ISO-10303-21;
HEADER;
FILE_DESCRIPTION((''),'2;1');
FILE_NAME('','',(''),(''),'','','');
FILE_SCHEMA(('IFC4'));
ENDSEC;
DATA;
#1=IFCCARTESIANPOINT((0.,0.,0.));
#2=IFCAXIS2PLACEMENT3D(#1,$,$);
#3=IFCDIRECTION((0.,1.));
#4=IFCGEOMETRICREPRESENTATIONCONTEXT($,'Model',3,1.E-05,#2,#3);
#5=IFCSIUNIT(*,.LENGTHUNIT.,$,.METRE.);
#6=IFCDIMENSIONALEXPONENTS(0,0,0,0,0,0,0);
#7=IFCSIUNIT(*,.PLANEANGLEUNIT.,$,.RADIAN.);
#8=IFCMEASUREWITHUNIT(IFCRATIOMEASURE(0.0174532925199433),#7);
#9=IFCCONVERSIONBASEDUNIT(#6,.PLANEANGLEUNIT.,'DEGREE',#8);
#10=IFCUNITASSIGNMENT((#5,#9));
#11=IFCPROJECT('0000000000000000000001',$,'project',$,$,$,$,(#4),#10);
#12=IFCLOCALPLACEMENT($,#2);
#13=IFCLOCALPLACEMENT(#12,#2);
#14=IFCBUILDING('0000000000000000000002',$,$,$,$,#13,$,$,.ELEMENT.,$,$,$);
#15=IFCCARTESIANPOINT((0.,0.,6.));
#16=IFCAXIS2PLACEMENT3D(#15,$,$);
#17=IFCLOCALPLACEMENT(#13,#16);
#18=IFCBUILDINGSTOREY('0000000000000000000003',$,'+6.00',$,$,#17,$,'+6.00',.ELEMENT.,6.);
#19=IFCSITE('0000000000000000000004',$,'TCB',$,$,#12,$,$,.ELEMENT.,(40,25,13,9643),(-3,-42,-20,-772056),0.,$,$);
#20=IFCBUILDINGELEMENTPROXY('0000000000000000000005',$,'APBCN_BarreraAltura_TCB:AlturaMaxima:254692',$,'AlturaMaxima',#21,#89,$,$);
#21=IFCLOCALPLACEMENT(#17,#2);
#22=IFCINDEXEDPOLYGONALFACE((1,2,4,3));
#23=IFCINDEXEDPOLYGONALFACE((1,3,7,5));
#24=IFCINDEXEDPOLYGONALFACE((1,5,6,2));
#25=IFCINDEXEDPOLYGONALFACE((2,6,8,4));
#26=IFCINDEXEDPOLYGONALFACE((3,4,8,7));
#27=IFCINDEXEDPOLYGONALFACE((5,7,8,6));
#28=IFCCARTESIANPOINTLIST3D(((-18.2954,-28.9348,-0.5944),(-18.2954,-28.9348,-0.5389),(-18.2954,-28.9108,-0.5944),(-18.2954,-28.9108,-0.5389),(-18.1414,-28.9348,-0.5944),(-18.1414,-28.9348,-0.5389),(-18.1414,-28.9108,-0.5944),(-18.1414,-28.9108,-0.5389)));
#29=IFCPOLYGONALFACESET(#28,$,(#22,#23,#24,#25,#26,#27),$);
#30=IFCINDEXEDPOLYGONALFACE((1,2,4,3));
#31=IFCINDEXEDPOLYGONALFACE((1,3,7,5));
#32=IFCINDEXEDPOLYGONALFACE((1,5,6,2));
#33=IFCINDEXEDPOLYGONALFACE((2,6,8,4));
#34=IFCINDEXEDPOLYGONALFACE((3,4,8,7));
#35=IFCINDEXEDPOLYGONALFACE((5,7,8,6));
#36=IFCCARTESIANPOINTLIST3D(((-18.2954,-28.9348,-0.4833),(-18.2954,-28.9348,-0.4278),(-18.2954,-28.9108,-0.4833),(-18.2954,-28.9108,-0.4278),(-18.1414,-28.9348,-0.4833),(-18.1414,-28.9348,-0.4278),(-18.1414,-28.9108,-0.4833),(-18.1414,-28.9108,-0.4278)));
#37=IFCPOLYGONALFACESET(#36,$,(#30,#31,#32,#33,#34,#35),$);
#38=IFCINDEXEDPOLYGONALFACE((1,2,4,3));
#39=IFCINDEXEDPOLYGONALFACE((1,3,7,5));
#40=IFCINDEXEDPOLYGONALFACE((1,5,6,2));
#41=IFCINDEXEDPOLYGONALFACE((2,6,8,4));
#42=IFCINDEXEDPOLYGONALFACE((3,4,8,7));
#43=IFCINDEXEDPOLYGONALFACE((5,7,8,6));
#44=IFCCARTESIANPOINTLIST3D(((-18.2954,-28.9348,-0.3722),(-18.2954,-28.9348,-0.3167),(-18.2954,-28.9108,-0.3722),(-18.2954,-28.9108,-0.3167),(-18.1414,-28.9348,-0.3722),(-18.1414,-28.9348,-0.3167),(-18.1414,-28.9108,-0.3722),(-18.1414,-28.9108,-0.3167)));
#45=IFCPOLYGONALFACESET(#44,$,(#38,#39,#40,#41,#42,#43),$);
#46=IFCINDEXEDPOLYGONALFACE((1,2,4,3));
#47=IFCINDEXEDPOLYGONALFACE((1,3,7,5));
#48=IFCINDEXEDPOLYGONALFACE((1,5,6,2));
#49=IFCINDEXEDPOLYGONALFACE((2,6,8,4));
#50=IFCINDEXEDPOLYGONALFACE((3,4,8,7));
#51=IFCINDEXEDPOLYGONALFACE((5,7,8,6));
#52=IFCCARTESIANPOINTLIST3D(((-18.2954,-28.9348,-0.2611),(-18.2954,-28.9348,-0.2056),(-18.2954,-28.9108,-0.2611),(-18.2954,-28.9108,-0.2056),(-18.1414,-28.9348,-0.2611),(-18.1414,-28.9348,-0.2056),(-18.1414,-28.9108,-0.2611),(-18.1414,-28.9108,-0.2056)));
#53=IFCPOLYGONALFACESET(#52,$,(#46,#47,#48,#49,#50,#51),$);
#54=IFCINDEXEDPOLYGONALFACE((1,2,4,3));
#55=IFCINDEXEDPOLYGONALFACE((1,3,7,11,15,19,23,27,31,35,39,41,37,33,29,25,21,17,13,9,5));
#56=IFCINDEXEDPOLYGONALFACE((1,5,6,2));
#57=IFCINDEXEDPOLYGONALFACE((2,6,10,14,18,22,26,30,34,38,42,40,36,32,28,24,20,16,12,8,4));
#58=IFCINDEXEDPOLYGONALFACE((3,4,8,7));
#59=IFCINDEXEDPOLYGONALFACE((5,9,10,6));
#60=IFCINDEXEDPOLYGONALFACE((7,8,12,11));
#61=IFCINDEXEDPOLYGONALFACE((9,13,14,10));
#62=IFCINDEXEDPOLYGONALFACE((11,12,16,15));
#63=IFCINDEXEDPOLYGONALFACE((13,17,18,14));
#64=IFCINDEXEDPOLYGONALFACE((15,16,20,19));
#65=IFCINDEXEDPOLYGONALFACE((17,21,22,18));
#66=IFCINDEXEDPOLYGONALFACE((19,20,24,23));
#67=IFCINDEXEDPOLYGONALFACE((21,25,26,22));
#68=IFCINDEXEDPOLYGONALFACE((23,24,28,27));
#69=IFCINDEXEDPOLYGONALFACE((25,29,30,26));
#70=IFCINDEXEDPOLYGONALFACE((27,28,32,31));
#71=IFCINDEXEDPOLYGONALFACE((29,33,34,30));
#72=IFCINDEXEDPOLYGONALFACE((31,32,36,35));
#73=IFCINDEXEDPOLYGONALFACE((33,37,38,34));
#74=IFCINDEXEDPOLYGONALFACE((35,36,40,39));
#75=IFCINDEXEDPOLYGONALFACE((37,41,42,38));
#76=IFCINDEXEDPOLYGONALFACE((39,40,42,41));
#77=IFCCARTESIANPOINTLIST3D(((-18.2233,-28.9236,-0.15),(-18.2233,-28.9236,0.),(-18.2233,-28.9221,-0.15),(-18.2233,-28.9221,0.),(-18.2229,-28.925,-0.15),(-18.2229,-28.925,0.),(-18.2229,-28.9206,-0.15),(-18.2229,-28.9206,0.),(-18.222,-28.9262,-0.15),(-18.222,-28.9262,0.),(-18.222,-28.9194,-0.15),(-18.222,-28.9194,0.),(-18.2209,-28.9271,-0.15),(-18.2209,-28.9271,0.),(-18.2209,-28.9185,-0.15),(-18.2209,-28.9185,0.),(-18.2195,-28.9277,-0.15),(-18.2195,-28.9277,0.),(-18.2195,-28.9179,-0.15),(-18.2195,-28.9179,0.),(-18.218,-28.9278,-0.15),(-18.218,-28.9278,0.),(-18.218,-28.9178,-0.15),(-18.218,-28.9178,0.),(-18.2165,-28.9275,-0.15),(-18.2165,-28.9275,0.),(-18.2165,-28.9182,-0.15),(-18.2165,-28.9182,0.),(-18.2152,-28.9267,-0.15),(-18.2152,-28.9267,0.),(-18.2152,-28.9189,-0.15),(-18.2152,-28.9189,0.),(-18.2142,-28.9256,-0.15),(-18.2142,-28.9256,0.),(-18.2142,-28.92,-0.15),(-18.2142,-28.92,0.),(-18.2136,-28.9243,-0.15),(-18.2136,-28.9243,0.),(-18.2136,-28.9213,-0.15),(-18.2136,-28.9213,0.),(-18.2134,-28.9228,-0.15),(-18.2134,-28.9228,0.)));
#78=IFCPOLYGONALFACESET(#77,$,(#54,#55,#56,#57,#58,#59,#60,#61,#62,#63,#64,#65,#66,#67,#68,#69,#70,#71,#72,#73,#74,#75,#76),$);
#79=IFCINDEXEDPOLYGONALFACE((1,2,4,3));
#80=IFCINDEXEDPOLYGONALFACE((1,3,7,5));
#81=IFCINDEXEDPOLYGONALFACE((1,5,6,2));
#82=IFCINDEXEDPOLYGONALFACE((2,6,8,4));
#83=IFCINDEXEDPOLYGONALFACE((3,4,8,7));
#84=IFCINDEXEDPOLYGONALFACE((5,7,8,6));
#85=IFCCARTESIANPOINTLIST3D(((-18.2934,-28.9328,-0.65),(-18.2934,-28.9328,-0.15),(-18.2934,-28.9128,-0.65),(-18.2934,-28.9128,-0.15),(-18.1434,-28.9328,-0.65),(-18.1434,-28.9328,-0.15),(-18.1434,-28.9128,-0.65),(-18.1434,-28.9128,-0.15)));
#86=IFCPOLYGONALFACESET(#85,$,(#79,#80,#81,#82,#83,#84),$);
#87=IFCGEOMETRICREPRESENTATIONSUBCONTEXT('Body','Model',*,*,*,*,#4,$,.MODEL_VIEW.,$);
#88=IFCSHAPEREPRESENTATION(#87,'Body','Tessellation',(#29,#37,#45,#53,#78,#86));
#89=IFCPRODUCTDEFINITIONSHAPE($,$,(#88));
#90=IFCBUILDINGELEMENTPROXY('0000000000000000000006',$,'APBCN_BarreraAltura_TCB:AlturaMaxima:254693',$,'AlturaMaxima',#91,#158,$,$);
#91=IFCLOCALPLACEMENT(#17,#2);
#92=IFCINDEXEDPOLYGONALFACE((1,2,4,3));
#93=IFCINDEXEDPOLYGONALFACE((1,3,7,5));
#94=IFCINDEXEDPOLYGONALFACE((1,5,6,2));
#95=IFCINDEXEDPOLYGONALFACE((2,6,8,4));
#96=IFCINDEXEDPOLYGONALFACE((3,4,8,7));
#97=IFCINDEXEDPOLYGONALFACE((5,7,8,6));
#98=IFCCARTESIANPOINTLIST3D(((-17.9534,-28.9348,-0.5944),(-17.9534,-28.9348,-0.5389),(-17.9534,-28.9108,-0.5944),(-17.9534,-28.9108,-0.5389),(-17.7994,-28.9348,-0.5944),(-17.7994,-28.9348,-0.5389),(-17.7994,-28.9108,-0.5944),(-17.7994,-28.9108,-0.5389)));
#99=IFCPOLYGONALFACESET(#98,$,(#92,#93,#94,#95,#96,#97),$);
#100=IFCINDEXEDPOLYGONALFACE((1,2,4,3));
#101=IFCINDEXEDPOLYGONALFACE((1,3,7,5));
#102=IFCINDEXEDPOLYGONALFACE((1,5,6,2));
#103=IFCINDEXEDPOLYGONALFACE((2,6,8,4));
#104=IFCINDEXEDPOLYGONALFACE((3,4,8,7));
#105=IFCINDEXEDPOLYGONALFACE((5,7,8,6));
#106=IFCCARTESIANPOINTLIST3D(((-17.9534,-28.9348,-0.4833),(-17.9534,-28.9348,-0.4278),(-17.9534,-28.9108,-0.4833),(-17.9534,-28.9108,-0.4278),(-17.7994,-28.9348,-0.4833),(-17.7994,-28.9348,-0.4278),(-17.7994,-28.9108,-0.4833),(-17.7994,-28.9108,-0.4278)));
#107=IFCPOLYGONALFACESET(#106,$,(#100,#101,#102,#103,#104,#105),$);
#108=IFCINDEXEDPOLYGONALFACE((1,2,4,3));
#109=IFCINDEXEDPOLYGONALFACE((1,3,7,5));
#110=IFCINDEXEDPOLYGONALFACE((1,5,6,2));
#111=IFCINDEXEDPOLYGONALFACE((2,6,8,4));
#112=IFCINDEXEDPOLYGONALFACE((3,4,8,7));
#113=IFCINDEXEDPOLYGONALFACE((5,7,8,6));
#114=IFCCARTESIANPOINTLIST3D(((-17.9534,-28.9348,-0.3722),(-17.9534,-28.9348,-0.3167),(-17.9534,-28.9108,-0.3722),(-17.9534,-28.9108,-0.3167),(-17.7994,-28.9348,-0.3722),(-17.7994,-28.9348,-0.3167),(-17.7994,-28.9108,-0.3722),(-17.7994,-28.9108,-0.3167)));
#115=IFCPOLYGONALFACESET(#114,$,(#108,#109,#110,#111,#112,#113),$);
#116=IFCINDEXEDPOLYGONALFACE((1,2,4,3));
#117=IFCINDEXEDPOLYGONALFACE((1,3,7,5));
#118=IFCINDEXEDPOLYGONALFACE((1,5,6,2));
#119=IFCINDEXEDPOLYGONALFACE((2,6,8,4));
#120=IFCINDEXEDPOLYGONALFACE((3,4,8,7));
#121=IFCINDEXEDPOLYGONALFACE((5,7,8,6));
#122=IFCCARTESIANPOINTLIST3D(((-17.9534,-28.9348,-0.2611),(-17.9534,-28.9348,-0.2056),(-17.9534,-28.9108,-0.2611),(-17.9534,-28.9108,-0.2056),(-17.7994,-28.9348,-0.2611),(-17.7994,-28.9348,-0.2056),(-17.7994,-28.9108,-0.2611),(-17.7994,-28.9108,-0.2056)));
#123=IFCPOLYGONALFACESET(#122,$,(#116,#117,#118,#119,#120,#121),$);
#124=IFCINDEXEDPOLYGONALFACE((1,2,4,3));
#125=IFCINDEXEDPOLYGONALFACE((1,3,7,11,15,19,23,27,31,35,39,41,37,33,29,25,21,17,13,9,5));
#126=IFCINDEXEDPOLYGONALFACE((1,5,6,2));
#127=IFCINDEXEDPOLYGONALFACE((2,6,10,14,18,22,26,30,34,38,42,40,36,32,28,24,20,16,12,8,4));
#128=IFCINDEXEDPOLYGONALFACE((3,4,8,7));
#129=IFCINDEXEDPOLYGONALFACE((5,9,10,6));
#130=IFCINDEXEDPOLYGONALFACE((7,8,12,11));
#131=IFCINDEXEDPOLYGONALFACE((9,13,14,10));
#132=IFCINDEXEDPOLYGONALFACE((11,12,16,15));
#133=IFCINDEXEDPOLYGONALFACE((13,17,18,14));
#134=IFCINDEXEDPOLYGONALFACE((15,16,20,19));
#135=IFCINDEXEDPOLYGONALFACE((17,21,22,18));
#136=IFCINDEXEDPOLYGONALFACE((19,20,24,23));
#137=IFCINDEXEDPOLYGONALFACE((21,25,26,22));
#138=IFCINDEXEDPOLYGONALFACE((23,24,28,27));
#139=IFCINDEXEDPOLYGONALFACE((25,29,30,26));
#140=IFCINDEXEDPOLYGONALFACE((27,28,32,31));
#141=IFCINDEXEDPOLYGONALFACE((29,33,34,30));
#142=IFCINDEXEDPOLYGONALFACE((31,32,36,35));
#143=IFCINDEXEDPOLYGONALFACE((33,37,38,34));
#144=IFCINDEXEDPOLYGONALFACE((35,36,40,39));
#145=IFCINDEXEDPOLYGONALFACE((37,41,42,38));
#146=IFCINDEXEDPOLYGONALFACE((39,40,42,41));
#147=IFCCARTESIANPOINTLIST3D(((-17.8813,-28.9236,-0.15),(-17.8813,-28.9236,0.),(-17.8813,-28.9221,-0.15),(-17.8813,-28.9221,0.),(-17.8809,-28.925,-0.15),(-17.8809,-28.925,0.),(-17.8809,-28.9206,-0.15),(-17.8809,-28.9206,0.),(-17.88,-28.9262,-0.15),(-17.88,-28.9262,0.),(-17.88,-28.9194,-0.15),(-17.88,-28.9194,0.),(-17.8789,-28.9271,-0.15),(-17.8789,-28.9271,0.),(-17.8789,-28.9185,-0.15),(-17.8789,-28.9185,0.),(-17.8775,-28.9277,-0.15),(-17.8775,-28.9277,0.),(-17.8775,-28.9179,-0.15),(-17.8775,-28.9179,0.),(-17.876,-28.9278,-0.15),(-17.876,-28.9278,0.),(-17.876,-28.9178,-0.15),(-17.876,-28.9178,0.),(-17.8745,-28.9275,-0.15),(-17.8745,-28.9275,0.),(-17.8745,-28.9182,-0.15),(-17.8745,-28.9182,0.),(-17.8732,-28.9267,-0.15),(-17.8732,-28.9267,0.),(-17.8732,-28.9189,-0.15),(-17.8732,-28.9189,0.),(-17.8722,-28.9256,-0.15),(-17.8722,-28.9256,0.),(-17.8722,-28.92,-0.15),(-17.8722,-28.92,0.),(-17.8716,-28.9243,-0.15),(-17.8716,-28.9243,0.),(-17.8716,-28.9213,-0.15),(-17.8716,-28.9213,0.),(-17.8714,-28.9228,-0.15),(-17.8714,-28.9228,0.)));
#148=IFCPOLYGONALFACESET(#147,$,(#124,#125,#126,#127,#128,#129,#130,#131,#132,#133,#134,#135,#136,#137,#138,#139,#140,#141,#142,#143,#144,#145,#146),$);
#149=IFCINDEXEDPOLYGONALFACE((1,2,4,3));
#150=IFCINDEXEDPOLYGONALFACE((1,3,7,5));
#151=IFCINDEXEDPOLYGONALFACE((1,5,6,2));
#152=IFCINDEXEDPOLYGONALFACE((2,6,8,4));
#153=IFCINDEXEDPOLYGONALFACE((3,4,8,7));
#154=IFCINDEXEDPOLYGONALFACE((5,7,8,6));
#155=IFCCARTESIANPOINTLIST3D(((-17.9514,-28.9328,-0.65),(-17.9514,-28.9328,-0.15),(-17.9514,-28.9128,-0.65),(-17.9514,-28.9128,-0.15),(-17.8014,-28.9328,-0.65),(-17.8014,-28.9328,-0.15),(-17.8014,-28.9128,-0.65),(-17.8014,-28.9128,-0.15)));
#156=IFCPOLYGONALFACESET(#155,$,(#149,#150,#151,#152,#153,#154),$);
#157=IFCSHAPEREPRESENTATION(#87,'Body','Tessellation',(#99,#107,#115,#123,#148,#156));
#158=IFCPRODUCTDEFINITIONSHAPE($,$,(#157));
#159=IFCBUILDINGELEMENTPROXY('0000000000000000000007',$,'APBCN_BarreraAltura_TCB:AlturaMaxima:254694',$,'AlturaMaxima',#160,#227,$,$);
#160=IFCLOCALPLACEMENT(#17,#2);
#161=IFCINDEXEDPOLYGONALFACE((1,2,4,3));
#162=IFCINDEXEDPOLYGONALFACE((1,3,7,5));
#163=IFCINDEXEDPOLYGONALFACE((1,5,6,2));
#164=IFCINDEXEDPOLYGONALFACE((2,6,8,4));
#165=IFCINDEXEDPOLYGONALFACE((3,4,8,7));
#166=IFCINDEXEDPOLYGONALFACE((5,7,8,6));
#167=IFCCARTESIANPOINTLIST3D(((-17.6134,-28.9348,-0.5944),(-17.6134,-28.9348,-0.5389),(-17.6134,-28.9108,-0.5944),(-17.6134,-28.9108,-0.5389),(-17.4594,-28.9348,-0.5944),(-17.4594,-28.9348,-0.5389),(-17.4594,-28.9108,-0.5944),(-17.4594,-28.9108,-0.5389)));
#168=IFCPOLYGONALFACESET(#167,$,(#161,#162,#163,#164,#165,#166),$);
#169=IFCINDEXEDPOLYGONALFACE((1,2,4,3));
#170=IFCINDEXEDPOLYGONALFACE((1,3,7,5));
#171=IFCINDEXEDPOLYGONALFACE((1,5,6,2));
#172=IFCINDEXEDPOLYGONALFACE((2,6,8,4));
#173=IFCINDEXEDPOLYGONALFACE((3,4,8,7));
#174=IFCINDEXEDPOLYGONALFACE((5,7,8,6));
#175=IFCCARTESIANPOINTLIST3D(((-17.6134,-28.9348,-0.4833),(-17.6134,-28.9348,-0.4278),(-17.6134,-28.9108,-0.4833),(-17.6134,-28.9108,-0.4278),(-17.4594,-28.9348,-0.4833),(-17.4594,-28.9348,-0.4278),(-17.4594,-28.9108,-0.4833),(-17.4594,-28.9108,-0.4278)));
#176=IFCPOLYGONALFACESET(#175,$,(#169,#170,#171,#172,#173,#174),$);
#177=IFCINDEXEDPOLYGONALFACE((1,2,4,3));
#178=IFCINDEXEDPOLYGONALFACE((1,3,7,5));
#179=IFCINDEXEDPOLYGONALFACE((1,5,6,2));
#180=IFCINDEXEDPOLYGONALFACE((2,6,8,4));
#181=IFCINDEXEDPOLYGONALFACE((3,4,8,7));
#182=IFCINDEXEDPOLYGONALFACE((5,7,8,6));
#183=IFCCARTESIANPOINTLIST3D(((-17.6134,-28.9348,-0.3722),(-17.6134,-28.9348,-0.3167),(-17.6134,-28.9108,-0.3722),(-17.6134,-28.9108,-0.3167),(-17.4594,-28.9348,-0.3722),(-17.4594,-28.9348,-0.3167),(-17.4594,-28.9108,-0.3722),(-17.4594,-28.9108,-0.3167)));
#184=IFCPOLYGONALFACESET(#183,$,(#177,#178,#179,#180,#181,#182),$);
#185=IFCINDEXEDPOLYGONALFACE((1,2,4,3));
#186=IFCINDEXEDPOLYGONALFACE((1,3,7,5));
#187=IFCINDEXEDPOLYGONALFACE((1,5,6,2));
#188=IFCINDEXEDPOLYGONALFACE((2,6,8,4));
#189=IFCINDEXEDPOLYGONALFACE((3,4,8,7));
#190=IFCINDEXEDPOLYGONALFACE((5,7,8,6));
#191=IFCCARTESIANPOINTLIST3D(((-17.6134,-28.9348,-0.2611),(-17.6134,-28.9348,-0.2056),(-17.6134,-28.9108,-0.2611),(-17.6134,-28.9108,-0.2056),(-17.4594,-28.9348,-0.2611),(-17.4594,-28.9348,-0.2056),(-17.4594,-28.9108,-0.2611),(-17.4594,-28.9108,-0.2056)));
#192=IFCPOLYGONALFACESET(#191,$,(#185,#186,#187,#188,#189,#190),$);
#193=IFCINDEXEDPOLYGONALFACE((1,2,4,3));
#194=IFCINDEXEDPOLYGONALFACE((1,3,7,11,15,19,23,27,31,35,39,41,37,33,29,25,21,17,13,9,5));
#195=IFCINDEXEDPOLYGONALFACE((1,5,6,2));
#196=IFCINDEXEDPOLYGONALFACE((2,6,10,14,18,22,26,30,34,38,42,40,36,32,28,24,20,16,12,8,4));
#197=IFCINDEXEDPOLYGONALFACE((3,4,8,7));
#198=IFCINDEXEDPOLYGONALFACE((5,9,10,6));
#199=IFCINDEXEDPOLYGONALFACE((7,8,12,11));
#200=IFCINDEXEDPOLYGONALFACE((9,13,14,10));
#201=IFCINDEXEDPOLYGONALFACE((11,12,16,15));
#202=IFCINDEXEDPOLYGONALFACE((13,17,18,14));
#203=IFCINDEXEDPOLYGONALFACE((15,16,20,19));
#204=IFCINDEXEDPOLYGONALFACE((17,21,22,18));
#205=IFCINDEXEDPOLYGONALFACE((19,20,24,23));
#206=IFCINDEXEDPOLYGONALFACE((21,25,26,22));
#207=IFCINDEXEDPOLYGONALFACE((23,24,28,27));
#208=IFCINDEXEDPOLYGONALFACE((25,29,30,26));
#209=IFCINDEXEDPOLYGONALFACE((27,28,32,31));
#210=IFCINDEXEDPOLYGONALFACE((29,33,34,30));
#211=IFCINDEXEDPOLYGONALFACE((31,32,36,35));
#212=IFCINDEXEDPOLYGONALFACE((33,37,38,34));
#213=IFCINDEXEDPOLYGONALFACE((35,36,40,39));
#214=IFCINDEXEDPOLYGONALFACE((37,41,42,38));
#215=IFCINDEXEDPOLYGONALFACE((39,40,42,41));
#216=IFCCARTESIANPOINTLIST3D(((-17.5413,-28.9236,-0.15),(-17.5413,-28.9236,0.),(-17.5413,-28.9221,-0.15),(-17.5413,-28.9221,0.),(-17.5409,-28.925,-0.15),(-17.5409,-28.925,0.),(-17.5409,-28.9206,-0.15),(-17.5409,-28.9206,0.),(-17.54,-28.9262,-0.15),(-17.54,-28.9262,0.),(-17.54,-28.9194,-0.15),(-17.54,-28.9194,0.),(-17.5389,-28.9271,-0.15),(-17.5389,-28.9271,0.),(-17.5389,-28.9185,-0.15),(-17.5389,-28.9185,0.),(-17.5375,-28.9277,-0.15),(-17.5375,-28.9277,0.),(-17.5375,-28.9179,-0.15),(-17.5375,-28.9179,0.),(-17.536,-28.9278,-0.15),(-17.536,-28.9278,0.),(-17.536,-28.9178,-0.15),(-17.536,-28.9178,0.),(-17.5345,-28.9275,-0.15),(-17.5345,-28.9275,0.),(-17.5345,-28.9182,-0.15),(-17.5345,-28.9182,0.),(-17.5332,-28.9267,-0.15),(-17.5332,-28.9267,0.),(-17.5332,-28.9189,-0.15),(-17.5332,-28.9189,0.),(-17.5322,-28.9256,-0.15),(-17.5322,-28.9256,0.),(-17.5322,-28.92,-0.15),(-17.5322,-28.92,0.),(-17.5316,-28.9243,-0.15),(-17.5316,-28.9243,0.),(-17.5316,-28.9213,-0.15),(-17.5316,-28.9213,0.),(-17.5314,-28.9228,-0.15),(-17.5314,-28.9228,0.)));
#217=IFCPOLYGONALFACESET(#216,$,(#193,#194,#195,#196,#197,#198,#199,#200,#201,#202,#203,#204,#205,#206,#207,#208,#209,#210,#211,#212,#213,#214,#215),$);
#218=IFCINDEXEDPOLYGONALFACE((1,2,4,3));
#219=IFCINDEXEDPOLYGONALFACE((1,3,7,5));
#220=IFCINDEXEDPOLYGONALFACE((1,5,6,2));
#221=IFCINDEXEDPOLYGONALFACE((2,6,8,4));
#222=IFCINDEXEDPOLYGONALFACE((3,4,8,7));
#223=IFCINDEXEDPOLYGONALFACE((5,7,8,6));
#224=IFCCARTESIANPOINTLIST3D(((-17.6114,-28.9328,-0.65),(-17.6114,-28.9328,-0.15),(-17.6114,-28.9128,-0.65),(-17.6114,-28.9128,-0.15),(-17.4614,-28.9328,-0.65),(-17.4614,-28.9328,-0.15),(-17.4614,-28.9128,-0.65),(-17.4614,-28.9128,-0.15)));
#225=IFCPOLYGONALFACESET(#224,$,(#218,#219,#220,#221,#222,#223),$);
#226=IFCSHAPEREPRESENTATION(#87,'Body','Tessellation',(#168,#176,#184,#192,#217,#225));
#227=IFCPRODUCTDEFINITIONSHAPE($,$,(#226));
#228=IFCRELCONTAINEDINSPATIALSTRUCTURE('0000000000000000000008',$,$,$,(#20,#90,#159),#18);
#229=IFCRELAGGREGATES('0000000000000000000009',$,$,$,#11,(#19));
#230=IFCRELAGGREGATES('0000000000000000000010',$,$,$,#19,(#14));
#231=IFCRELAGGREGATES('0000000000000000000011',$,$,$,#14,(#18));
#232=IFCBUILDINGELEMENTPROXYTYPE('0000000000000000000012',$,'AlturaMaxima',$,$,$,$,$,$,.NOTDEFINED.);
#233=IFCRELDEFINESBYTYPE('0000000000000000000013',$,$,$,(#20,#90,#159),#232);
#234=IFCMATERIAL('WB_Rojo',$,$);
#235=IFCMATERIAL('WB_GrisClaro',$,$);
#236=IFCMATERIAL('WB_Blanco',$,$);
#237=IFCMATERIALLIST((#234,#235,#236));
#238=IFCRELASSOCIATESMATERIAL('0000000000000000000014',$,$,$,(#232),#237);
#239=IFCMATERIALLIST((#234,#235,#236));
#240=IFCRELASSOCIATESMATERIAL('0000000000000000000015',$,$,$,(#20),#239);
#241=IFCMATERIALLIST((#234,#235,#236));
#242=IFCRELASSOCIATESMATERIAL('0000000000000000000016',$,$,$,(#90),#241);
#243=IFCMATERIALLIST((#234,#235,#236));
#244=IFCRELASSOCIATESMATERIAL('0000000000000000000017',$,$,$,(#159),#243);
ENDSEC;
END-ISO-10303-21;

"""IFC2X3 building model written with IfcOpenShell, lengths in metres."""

from ifc_helpers import new_model, entity, si_unit, converted_unit, direction, frame, frame_2d, origin, origin_2d_with_axis, place, context, subcontext, project, spatial, rectangle, circle, extrude, source, transform, mapped, material, material_list, type_object, type_shapes, element, save


model = new_model("IFC2X3")

# Units and contexts
model_context = context("Model", 3, precision=1e-05, world=origin(), true_north=direction((0.0, 1.0)))
body_context = subcontext(model_context, "Body", "Model", "MODEL_VIEW")
ifc_project = project(units=[si_unit("LENGTHUNIT", "METRE"), converted_unit("PLANEANGLEUNIT", "DEGREE", entity("IfcRatioMeasure", 0.0174532925199433), si_unit("PLANEANGLEUNIT", "RADIAN"), dimensions=[0, 0, 0, 0, 0, 0, 0])], contexts=[model_context])

# Site, building, storey
site_placement = place(None, origin())
site = spatial("IfcSite", under=ifc_project, at=site_placement, Name="TCB", CompositionType="ELEMENT", RefLatitude=(40, 25, 13, 9643), RefLongitude=(-3, -42, -20, -772056), RefElevation=0.0)
building_placement = place(site_placement, origin())
building = spatial("IfcBuilding", under=site, at=building_placement, CompositionType="ELEMENT")
storey_placement = place(building_placement, frame((0.0, 0.0, 6.0)))
storey = spatial("IfcBuildingStorey", under=building, at=storey_placement, Name="+6.00", LongName="+6.00", CompositionType="ELEMENT", Elevation=6.0)

# Building element proxies
ifc_material_1 = material(Name="WB_Rojo")
ifc_material_2 = material(Name="WB_GrisClaro")
ifc_material_3 = material(Name="WB_Blanco")
ifc_material_list_1 = material_list([ifc_material_1, ifc_material_2, ifc_material_3])
building_element_proxy_type = type_object("IfcBuildingElementProxyType", Name="AlturaMaxima", PredefinedType="NOTDEFINED", material=ifc_material_list_1)
shared_shape = source(origin(), body_context, "Body", "SweptSolid", [
    extrude(rectangle(XDim=0.154, YDim=0.024, at=frame_2d((0.0, 0.0), x_axis=(1.0, 0.0))), frame((0.0, 0.0, -0.5944), z_axis=(0.0, 0.0, 1.0), x_axis=(-1.0, 0.0, 0.0)), (0.0, 0.0, 1.0), 0.0556),
    extrude(rectangle(XDim=0.154, YDim=0.024, at=frame_2d((0.0, 0.0), x_axis=(1.0, 0.0))), frame((0.0, 0.0, -0.4833), z_axis=(0.0, 0.0, 1.0), x_axis=(-1.0, 0.0, 0.0)), (0.0, 0.0, 1.0), 0.0556),
    extrude(rectangle(XDim=0.154, YDim=0.024, at=frame_2d((0.0, 0.0), x_axis=(1.0, 0.0))), frame((0.0, 0.0, -0.3722), z_axis=(0.0, 0.0, 1.0), x_axis=(-1.0, 0.0, 0.0)), (0.0, 0.0, 1.0), 0.0556),
    extrude(rectangle(XDim=0.154, YDim=0.024, at=frame_2d((0.0, 0.0), x_axis=(1.0, 0.0))), frame((0.0, 0.0, -0.2611), z_axis=(0.0, 0.0, 1.0), x_axis=(-1.0, 0.0, 0.0)), (0.0, 0.0, 1.0), 0.0556),
    extrude(circle(Radius=0.005, at=frame_2d((0.0, 0.0), x_axis=(1.0, 0.0))), frame((0.0, 0.0, -0.15)), (0.0, 0.0, 1.0), 0.15),
    extrude(rectangle(XDim=0.02, YDim=0.15, at=origin_2d_with_axis()), frame((0.0, 0.0, -0.65), z_axis=(0.0, 0.0, 1.0), x_axis=(0.0, 1.0, 0.0)), (0.0, 0.0, 1.0), 0.5),
])
type_shapes(building_element_proxy_type, [shared_shape])
ifc_material_list_2 = material_list([ifc_material_1, ifc_material_2, ifc_material_3])
proxy_1_placement = place(storey_placement, frame((-18.2184, -28.9228, 0.0)))
element("IfcBuildingElementProxy", 1, at=proxy_1_placement, inside=storey, type_object=building_element_proxy_type, material=ifc_material_list_2, Name="APBCN_BarreraAltura_TCB:AlturaMaxima:254692", ObjectType="AlturaMaxima", context=body_context, shape_type="MappedRepresentation", body=[
    mapped(shared_shape, transform((0.0, 0.0, 0.0), scale=1.0)),
])
ifc_material_list_3 = material_list([ifc_material_1, ifc_material_2, ifc_material_3])
proxy_2_placement = place(storey_placement, frame((-17.8764, -28.9228, 0.0)))
element("IfcBuildingElementProxy", 2, at=proxy_2_placement, inside=storey, type_object=building_element_proxy_type, material=ifc_material_list_3, Name="APBCN_BarreraAltura_TCB:AlturaMaxima:254693", ObjectType="AlturaMaxima", context=body_context, shape_type="MappedRepresentation", body=[
    mapped(shared_shape, transform((0.0, 0.0, 0.0), scale=1.0)),
])
ifc_material_list_4 = material_list([ifc_material_1, ifc_material_2, ifc_material_3])
proxy_3_placement = place(storey_placement, frame((-17.5364, -28.9228, 0.0)))
element("IfcBuildingElementProxy", 3, at=proxy_3_placement, inside=storey, type_object=building_element_proxy_type, material=ifc_material_list_4, Name="APBCN_BarreraAltura_TCB:AlturaMaxima:254694", ObjectType="AlturaMaxima", context=body_context, shape_type="MappedRepresentation", body=[
    mapped(shared_shape, transform((0.0, 0.0, 0.0), scale=1.0)),
])

save(model, "model.ifc")
